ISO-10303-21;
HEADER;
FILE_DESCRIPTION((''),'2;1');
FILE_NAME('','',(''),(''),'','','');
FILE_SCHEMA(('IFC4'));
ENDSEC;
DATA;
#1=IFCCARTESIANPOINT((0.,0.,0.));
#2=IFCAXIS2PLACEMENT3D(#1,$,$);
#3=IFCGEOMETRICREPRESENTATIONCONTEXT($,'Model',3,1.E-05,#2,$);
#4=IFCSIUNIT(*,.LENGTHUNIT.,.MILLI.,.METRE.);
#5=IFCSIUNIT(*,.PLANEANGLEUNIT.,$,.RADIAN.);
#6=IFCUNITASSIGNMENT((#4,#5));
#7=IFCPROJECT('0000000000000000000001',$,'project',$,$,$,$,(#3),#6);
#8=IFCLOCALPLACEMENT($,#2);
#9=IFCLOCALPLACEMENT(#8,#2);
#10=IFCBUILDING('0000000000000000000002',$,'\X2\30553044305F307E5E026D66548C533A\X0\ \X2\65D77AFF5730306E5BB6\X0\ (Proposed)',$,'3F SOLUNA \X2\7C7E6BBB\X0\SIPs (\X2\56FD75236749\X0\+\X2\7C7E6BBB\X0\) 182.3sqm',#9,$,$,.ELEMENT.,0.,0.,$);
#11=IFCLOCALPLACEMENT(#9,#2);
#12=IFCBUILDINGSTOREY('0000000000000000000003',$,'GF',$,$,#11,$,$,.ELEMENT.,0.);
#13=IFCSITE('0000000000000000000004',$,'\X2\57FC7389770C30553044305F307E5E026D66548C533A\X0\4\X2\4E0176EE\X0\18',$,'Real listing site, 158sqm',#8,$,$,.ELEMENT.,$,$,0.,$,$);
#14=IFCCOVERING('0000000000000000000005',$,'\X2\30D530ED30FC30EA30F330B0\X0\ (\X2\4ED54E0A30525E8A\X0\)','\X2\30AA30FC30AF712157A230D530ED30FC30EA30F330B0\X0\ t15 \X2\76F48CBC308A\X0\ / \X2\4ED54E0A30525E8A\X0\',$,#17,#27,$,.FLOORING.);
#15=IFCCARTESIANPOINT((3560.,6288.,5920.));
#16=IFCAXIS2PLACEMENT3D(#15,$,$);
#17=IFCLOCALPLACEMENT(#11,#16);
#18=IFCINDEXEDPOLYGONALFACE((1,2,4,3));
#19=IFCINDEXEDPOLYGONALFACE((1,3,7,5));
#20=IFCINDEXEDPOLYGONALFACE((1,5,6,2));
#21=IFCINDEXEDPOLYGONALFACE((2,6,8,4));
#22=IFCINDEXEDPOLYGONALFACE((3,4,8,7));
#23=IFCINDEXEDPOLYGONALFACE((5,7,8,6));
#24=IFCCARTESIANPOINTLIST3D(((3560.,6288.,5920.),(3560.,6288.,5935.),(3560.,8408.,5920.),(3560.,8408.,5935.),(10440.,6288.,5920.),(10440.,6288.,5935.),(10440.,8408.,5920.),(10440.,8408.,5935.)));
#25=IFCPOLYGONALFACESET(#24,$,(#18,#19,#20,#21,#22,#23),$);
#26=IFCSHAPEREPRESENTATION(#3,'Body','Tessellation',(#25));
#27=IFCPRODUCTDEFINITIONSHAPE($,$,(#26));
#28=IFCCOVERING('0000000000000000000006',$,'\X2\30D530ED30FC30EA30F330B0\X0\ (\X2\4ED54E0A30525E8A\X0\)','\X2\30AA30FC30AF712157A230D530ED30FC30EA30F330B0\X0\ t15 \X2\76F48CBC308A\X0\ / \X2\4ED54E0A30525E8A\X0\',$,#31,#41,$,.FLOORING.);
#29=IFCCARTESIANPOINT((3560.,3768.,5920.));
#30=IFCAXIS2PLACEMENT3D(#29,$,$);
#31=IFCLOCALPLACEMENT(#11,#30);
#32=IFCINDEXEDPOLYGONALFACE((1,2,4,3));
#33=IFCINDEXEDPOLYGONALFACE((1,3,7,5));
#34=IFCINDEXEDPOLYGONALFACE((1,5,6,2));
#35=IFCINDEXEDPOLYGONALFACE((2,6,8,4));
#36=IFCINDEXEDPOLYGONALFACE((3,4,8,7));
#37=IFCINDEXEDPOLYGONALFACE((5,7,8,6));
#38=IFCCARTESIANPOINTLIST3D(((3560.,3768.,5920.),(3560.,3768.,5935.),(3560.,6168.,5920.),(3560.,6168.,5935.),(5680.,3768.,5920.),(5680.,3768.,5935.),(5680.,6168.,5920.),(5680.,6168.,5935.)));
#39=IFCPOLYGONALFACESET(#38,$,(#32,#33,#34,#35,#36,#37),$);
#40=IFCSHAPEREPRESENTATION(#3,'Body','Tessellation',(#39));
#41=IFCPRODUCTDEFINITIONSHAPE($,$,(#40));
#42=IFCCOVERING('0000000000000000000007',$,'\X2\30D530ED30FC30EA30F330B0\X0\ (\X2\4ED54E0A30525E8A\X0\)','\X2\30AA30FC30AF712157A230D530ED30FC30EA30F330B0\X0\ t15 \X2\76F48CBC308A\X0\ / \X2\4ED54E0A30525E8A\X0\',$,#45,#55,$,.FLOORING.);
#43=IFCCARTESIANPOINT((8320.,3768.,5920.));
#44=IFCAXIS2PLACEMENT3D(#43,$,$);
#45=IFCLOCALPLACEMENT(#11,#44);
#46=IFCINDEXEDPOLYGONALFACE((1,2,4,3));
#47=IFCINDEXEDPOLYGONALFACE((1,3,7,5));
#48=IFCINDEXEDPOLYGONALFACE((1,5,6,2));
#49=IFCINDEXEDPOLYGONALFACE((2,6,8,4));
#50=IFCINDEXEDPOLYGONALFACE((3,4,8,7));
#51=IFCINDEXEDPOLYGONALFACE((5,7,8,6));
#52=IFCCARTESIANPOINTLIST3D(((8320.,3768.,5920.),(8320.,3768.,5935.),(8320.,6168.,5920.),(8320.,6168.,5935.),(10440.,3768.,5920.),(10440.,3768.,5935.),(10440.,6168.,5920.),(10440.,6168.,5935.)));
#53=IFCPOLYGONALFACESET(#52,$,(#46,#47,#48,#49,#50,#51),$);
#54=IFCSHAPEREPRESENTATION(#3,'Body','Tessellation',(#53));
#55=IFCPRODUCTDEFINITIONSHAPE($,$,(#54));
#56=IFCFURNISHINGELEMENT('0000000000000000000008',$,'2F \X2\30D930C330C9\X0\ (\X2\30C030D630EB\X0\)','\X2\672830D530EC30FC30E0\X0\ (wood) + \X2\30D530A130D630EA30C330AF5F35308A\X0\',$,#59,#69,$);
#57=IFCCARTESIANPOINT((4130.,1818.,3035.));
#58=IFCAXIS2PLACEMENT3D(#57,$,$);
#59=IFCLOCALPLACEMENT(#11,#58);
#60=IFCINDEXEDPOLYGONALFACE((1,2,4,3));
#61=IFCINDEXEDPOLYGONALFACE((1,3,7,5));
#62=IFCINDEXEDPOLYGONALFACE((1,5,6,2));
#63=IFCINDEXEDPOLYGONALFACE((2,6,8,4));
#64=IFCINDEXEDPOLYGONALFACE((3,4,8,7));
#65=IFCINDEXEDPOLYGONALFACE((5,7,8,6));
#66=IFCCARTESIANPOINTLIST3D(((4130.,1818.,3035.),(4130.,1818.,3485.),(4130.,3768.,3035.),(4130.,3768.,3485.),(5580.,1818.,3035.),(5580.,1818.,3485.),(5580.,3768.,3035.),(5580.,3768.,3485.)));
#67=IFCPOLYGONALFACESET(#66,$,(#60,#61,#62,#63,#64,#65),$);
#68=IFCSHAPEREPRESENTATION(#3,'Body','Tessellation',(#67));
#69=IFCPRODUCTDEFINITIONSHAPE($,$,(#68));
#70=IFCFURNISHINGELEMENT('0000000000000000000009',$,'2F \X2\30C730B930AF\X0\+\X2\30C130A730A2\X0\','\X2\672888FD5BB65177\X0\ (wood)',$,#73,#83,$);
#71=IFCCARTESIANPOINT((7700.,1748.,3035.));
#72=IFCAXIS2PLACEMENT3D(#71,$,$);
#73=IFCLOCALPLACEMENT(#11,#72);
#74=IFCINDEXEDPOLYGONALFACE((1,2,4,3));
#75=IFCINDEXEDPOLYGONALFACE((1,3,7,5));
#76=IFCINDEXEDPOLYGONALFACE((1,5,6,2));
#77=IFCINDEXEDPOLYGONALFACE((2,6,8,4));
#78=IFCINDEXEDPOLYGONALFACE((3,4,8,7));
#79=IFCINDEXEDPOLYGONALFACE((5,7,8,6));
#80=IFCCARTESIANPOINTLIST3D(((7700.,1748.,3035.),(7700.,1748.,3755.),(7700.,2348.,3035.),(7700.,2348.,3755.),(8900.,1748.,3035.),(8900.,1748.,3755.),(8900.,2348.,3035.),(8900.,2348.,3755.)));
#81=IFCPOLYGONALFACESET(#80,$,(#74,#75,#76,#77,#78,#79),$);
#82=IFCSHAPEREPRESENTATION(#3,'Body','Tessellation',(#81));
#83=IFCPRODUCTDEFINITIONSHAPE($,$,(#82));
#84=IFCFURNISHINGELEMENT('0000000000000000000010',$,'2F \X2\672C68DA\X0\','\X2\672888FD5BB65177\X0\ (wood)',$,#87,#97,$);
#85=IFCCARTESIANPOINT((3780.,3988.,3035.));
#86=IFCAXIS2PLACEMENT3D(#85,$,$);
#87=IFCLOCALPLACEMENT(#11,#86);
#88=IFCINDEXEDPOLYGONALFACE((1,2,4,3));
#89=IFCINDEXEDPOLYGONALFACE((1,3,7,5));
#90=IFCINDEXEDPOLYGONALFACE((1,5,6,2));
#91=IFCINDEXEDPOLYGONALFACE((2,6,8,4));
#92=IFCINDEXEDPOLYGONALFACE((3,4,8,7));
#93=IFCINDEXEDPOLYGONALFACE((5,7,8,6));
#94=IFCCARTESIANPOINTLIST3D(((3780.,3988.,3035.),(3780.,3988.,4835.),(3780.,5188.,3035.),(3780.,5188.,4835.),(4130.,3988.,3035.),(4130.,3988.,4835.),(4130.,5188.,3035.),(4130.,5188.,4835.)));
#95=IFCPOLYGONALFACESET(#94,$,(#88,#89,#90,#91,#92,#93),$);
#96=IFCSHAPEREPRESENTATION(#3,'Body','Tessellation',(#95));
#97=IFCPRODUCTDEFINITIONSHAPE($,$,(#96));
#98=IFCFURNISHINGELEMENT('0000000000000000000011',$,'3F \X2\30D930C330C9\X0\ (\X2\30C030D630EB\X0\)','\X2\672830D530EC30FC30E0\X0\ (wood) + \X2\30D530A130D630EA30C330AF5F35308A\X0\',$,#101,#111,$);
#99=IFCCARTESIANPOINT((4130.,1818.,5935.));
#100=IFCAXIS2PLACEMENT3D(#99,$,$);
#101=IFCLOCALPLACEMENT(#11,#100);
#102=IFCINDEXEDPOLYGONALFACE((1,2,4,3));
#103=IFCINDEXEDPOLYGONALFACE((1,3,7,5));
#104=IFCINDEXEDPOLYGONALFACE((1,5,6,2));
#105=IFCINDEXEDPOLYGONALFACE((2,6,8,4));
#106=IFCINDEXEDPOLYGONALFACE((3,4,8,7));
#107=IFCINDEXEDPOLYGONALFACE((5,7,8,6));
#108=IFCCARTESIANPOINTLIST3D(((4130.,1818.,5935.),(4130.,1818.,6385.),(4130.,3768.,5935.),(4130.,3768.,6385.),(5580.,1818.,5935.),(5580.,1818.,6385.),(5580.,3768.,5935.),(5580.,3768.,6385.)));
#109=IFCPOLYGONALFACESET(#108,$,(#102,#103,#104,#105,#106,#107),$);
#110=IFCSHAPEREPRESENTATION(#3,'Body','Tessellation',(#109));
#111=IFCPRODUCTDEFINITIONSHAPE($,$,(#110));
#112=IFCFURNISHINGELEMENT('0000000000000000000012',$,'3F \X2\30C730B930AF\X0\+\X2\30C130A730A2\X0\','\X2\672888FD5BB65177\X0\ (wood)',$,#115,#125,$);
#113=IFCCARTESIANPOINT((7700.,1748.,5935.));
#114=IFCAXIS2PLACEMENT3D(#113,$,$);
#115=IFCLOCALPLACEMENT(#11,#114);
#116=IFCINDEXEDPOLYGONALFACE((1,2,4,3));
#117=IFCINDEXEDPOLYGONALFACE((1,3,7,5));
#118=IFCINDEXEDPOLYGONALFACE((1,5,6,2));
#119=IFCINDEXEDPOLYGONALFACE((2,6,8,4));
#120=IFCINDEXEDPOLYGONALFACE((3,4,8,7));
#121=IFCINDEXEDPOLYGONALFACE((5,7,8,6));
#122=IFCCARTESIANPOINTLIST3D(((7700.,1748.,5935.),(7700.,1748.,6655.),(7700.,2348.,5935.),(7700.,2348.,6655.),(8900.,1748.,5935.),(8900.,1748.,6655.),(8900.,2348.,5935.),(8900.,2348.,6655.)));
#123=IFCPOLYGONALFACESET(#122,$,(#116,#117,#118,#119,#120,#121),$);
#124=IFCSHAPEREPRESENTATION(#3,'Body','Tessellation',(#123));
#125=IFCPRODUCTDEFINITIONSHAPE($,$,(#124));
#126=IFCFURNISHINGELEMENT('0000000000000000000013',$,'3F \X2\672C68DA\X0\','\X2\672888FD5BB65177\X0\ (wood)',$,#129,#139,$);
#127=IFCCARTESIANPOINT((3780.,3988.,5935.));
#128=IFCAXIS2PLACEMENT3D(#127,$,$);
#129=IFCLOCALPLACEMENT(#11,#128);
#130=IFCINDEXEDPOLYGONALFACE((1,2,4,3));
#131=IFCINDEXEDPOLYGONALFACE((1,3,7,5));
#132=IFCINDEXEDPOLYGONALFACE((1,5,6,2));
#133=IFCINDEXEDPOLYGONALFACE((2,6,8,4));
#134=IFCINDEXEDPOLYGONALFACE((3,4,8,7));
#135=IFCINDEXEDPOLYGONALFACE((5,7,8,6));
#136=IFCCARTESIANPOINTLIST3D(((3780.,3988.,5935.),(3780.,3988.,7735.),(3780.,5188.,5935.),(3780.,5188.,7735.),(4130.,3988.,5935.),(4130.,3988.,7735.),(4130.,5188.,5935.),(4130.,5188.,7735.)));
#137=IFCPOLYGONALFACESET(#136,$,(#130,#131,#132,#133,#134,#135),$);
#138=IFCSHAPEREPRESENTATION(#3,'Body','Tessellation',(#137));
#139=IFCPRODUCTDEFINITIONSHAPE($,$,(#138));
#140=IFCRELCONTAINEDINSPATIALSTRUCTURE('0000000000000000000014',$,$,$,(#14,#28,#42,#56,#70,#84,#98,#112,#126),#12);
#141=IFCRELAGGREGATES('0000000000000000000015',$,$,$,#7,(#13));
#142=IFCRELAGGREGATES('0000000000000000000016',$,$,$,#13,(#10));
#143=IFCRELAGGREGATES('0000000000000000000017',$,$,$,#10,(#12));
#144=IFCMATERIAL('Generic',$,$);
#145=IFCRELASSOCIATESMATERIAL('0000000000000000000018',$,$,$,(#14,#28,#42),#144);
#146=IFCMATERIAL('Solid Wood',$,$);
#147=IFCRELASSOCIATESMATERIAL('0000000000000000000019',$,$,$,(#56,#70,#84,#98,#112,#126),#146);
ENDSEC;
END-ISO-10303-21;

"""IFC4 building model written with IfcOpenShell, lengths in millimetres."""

from ifc_helpers import new_model, si_unit, frame, frame_2d, origin, place, context, project, spatial, rectangle, extrude, material, element, save


model = new_model("IFC4")

# Units and contexts
model_context = context("Model", 3, precision=1e-05, world=origin())
ifc_project = project(units=[si_unit("LENGTHUNIT", "METRE", prefix="MILLI"), si_unit("PLANEANGLEUNIT", "RADIAN")], contexts=[model_context])

# Site, building, storey
site_placement = place(None, origin())
site = spatial("IfcSite", under=ifc_project, at=site_placement, Name="埼玉県さいたま市浦和区4丁目18", ObjectType="Real listing site, 158sqm", CompositionType="ELEMENT", RefElevation=0.0)
building_placement = place(site_placement, origin())
building = spatial("IfcBuilding", under=site, at=building_placement, Name="さいたま市浦和区 旗竿地の家 (Proposed)", ObjectType="3F SOLUNA 籾殻SIPs (国産杉+籾殻) 182.3sqm", CompositionType="ELEMENT", ElevationOfRefHeight=0.0, ElevationOfTerrain=0.0)
storey_placement = place(building_placement, origin())
storey = spatial("IfcBuildingStorey", under=building, at=storey_placement, Name="GF", CompositionType="ELEMENT", Elevation=0.0)

# Shared definitions
ifc_material_1 = material(Name="Solid Wood")

# Shared definitions
ifc_material_2 = material(Name="Generic")

# Coverings
covering_1_placement = place(storey_placement, frame((3560.0, 6288.0, 5920.0)))
element("IfcCovering", 1, at=covering_1_placement, inside=storey, material=ifc_material_2, Name="フローリング (仕上げ床)", Description="オーク無垢フローリング t15 直貼り / 仕上げ床", PredefinedType="FLOORING", context=model_context, shape_type="SweptSolid", body=[
    extrude(rectangle(XDim=6880.0, YDim=2120.0, at=frame_2d((3440.0, 1060.0))), frame((3560.0, 6288.0, 5920.0)), (0.0, 0.0, 1.0), 15.0),
])
covering_2_placement = place(storey_placement, frame((3560.0, 3768.0, 5920.0)))
element("IfcCovering", 2, at=covering_2_placement, inside=storey, material=ifc_material_2, Name="フローリング (仕上げ床)", Description="オーク無垢フローリング t15 直貼り / 仕上げ床", PredefinedType="FLOORING", context=model_context, shape_type="SweptSolid", body=[
    extrude(rectangle(XDim=2120.0, YDim=2400.0, at=frame_2d((1060.0, 1200.0))), frame((3560.0, 3768.0, 5920.0)), (0.0, 0.0, 1.0), 15.0),
])
covering_3_placement = place(storey_placement, frame((8320.0, 3768.0, 5920.0)))
element("IfcCovering", 3, at=covering_3_placement, inside=storey, material=ifc_material_2, Name="フローリング (仕上げ床)", Description="オーク無垢フローリング t15 直貼り / 仕上げ床", PredefinedType="FLOORING", context=model_context, shape_type="SweptSolid", body=[
    extrude(rectangle(XDim=2120.0, YDim=2400.0, at=frame_2d((1060.0, 1200.0))), frame((8320.0, 3768.0, 5920.0)), (0.0, 0.0, 1.0), 15.0),
])

# Furnishing elements
furnishing_1_placement = place(storey_placement, frame((4130.0, 1818.0, 3035.0)))
element("IfcFurnishingElement", 4, at=furnishing_1_placement, inside=storey, material=ifc_material_1, Name="2F ベッド (ダブル)", Description="木フレーム (wood) + ファブリック張り", context=model_context, shape_type="SweptSolid", body=[
    extrude(rectangle(XDim=1450.0, YDim=1950.0, at=frame_2d((725.0, 975.0))), frame((4130.0, 1818.0, 3035.0)), (0.0, 0.0, 1.0), 450.0),
])
furnishing_2_placement = place(storey_placement, frame((7700.0, 1748.0, 3035.0)))
element("IfcFurnishingElement", 5, at=furnishing_2_placement, inside=storey, material=ifc_material_1, Name="2F デスク+チェア", Description="木製家具 (wood)", context=model_context, shape_type="SweptSolid", body=[
    extrude(rectangle(XDim=1200.0, YDim=600.0, at=frame_2d((600.0, 300.0))), frame((7700.0, 1748.0, 3035.0)), (0.0, 0.0, 1.0), 720.0),
])
furnishing_3_placement = place(storey_placement, frame((3780.0, 3988.0, 3035.0)))
element("IfcFurnishingElement", 6, at=furnishing_3_placement, inside=storey, material=ifc_material_1, Name="2F 本棚", Description="木製家具 (wood)", context=model_context, shape_type="SweptSolid", body=[
    extrude(rectangle(XDim=350.0, YDim=1200.0, at=frame_2d((175.0, 600.0))), frame((3780.0, 3988.0, 3035.0)), (0.0, 0.0, 1.0), 1800.0),
])
furnishing_4_placement = place(storey_placement, frame((4130.0, 1818.0, 5935.0)))
element("IfcFurnishingElement", 7, at=furnishing_4_placement, inside=storey, material=ifc_material_1, Name="3F ベッド (ダブル)", Description="木フレーム (wood) + ファブリック張り", context=model_context, shape_type="SweptSolid", body=[
    extrude(rectangle(XDim=1450.0, YDim=1950.0, at=frame_2d((725.0, 975.0))), frame((4130.0, 1818.0, 5935.0)), (0.0, 0.0, 1.0), 450.0),
])
furnishing_5_placement = place(storey_placement, frame((7700.0, 1748.0, 5935.0)))
element("IfcFurnishingElement", 8, at=furnishing_5_placement, inside=storey, material=ifc_material_1, Name="3F デスク+チェア", Description="木製家具 (wood)", context=model_context, shape_type="SweptSolid", body=[
    extrude(rectangle(XDim=1200.0, YDim=600.0, at=frame_2d((600.0, 300.0))), frame((7700.0, 1748.0, 5935.0)), (0.0, 0.0, 1.0), 720.0),
])
furnishing_6_placement = place(storey_placement, frame((3780.0, 3988.0, 5935.0)))
element("IfcFurnishingElement", 9, at=furnishing_6_placement, inside=storey, material=ifc_material_1, Name="3F 本棚", Description="木製家具 (wood)", context=model_context, shape_type="SweptSolid", body=[
    extrude(rectangle(XDim=350.0, YDim=1200.0, at=frame_2d((175.0, 600.0))), frame((3780.0, 3988.0, 5935.0)), (0.0, 0.0, 1.0), 1800.0),
])

save(model, "model.ifc")
